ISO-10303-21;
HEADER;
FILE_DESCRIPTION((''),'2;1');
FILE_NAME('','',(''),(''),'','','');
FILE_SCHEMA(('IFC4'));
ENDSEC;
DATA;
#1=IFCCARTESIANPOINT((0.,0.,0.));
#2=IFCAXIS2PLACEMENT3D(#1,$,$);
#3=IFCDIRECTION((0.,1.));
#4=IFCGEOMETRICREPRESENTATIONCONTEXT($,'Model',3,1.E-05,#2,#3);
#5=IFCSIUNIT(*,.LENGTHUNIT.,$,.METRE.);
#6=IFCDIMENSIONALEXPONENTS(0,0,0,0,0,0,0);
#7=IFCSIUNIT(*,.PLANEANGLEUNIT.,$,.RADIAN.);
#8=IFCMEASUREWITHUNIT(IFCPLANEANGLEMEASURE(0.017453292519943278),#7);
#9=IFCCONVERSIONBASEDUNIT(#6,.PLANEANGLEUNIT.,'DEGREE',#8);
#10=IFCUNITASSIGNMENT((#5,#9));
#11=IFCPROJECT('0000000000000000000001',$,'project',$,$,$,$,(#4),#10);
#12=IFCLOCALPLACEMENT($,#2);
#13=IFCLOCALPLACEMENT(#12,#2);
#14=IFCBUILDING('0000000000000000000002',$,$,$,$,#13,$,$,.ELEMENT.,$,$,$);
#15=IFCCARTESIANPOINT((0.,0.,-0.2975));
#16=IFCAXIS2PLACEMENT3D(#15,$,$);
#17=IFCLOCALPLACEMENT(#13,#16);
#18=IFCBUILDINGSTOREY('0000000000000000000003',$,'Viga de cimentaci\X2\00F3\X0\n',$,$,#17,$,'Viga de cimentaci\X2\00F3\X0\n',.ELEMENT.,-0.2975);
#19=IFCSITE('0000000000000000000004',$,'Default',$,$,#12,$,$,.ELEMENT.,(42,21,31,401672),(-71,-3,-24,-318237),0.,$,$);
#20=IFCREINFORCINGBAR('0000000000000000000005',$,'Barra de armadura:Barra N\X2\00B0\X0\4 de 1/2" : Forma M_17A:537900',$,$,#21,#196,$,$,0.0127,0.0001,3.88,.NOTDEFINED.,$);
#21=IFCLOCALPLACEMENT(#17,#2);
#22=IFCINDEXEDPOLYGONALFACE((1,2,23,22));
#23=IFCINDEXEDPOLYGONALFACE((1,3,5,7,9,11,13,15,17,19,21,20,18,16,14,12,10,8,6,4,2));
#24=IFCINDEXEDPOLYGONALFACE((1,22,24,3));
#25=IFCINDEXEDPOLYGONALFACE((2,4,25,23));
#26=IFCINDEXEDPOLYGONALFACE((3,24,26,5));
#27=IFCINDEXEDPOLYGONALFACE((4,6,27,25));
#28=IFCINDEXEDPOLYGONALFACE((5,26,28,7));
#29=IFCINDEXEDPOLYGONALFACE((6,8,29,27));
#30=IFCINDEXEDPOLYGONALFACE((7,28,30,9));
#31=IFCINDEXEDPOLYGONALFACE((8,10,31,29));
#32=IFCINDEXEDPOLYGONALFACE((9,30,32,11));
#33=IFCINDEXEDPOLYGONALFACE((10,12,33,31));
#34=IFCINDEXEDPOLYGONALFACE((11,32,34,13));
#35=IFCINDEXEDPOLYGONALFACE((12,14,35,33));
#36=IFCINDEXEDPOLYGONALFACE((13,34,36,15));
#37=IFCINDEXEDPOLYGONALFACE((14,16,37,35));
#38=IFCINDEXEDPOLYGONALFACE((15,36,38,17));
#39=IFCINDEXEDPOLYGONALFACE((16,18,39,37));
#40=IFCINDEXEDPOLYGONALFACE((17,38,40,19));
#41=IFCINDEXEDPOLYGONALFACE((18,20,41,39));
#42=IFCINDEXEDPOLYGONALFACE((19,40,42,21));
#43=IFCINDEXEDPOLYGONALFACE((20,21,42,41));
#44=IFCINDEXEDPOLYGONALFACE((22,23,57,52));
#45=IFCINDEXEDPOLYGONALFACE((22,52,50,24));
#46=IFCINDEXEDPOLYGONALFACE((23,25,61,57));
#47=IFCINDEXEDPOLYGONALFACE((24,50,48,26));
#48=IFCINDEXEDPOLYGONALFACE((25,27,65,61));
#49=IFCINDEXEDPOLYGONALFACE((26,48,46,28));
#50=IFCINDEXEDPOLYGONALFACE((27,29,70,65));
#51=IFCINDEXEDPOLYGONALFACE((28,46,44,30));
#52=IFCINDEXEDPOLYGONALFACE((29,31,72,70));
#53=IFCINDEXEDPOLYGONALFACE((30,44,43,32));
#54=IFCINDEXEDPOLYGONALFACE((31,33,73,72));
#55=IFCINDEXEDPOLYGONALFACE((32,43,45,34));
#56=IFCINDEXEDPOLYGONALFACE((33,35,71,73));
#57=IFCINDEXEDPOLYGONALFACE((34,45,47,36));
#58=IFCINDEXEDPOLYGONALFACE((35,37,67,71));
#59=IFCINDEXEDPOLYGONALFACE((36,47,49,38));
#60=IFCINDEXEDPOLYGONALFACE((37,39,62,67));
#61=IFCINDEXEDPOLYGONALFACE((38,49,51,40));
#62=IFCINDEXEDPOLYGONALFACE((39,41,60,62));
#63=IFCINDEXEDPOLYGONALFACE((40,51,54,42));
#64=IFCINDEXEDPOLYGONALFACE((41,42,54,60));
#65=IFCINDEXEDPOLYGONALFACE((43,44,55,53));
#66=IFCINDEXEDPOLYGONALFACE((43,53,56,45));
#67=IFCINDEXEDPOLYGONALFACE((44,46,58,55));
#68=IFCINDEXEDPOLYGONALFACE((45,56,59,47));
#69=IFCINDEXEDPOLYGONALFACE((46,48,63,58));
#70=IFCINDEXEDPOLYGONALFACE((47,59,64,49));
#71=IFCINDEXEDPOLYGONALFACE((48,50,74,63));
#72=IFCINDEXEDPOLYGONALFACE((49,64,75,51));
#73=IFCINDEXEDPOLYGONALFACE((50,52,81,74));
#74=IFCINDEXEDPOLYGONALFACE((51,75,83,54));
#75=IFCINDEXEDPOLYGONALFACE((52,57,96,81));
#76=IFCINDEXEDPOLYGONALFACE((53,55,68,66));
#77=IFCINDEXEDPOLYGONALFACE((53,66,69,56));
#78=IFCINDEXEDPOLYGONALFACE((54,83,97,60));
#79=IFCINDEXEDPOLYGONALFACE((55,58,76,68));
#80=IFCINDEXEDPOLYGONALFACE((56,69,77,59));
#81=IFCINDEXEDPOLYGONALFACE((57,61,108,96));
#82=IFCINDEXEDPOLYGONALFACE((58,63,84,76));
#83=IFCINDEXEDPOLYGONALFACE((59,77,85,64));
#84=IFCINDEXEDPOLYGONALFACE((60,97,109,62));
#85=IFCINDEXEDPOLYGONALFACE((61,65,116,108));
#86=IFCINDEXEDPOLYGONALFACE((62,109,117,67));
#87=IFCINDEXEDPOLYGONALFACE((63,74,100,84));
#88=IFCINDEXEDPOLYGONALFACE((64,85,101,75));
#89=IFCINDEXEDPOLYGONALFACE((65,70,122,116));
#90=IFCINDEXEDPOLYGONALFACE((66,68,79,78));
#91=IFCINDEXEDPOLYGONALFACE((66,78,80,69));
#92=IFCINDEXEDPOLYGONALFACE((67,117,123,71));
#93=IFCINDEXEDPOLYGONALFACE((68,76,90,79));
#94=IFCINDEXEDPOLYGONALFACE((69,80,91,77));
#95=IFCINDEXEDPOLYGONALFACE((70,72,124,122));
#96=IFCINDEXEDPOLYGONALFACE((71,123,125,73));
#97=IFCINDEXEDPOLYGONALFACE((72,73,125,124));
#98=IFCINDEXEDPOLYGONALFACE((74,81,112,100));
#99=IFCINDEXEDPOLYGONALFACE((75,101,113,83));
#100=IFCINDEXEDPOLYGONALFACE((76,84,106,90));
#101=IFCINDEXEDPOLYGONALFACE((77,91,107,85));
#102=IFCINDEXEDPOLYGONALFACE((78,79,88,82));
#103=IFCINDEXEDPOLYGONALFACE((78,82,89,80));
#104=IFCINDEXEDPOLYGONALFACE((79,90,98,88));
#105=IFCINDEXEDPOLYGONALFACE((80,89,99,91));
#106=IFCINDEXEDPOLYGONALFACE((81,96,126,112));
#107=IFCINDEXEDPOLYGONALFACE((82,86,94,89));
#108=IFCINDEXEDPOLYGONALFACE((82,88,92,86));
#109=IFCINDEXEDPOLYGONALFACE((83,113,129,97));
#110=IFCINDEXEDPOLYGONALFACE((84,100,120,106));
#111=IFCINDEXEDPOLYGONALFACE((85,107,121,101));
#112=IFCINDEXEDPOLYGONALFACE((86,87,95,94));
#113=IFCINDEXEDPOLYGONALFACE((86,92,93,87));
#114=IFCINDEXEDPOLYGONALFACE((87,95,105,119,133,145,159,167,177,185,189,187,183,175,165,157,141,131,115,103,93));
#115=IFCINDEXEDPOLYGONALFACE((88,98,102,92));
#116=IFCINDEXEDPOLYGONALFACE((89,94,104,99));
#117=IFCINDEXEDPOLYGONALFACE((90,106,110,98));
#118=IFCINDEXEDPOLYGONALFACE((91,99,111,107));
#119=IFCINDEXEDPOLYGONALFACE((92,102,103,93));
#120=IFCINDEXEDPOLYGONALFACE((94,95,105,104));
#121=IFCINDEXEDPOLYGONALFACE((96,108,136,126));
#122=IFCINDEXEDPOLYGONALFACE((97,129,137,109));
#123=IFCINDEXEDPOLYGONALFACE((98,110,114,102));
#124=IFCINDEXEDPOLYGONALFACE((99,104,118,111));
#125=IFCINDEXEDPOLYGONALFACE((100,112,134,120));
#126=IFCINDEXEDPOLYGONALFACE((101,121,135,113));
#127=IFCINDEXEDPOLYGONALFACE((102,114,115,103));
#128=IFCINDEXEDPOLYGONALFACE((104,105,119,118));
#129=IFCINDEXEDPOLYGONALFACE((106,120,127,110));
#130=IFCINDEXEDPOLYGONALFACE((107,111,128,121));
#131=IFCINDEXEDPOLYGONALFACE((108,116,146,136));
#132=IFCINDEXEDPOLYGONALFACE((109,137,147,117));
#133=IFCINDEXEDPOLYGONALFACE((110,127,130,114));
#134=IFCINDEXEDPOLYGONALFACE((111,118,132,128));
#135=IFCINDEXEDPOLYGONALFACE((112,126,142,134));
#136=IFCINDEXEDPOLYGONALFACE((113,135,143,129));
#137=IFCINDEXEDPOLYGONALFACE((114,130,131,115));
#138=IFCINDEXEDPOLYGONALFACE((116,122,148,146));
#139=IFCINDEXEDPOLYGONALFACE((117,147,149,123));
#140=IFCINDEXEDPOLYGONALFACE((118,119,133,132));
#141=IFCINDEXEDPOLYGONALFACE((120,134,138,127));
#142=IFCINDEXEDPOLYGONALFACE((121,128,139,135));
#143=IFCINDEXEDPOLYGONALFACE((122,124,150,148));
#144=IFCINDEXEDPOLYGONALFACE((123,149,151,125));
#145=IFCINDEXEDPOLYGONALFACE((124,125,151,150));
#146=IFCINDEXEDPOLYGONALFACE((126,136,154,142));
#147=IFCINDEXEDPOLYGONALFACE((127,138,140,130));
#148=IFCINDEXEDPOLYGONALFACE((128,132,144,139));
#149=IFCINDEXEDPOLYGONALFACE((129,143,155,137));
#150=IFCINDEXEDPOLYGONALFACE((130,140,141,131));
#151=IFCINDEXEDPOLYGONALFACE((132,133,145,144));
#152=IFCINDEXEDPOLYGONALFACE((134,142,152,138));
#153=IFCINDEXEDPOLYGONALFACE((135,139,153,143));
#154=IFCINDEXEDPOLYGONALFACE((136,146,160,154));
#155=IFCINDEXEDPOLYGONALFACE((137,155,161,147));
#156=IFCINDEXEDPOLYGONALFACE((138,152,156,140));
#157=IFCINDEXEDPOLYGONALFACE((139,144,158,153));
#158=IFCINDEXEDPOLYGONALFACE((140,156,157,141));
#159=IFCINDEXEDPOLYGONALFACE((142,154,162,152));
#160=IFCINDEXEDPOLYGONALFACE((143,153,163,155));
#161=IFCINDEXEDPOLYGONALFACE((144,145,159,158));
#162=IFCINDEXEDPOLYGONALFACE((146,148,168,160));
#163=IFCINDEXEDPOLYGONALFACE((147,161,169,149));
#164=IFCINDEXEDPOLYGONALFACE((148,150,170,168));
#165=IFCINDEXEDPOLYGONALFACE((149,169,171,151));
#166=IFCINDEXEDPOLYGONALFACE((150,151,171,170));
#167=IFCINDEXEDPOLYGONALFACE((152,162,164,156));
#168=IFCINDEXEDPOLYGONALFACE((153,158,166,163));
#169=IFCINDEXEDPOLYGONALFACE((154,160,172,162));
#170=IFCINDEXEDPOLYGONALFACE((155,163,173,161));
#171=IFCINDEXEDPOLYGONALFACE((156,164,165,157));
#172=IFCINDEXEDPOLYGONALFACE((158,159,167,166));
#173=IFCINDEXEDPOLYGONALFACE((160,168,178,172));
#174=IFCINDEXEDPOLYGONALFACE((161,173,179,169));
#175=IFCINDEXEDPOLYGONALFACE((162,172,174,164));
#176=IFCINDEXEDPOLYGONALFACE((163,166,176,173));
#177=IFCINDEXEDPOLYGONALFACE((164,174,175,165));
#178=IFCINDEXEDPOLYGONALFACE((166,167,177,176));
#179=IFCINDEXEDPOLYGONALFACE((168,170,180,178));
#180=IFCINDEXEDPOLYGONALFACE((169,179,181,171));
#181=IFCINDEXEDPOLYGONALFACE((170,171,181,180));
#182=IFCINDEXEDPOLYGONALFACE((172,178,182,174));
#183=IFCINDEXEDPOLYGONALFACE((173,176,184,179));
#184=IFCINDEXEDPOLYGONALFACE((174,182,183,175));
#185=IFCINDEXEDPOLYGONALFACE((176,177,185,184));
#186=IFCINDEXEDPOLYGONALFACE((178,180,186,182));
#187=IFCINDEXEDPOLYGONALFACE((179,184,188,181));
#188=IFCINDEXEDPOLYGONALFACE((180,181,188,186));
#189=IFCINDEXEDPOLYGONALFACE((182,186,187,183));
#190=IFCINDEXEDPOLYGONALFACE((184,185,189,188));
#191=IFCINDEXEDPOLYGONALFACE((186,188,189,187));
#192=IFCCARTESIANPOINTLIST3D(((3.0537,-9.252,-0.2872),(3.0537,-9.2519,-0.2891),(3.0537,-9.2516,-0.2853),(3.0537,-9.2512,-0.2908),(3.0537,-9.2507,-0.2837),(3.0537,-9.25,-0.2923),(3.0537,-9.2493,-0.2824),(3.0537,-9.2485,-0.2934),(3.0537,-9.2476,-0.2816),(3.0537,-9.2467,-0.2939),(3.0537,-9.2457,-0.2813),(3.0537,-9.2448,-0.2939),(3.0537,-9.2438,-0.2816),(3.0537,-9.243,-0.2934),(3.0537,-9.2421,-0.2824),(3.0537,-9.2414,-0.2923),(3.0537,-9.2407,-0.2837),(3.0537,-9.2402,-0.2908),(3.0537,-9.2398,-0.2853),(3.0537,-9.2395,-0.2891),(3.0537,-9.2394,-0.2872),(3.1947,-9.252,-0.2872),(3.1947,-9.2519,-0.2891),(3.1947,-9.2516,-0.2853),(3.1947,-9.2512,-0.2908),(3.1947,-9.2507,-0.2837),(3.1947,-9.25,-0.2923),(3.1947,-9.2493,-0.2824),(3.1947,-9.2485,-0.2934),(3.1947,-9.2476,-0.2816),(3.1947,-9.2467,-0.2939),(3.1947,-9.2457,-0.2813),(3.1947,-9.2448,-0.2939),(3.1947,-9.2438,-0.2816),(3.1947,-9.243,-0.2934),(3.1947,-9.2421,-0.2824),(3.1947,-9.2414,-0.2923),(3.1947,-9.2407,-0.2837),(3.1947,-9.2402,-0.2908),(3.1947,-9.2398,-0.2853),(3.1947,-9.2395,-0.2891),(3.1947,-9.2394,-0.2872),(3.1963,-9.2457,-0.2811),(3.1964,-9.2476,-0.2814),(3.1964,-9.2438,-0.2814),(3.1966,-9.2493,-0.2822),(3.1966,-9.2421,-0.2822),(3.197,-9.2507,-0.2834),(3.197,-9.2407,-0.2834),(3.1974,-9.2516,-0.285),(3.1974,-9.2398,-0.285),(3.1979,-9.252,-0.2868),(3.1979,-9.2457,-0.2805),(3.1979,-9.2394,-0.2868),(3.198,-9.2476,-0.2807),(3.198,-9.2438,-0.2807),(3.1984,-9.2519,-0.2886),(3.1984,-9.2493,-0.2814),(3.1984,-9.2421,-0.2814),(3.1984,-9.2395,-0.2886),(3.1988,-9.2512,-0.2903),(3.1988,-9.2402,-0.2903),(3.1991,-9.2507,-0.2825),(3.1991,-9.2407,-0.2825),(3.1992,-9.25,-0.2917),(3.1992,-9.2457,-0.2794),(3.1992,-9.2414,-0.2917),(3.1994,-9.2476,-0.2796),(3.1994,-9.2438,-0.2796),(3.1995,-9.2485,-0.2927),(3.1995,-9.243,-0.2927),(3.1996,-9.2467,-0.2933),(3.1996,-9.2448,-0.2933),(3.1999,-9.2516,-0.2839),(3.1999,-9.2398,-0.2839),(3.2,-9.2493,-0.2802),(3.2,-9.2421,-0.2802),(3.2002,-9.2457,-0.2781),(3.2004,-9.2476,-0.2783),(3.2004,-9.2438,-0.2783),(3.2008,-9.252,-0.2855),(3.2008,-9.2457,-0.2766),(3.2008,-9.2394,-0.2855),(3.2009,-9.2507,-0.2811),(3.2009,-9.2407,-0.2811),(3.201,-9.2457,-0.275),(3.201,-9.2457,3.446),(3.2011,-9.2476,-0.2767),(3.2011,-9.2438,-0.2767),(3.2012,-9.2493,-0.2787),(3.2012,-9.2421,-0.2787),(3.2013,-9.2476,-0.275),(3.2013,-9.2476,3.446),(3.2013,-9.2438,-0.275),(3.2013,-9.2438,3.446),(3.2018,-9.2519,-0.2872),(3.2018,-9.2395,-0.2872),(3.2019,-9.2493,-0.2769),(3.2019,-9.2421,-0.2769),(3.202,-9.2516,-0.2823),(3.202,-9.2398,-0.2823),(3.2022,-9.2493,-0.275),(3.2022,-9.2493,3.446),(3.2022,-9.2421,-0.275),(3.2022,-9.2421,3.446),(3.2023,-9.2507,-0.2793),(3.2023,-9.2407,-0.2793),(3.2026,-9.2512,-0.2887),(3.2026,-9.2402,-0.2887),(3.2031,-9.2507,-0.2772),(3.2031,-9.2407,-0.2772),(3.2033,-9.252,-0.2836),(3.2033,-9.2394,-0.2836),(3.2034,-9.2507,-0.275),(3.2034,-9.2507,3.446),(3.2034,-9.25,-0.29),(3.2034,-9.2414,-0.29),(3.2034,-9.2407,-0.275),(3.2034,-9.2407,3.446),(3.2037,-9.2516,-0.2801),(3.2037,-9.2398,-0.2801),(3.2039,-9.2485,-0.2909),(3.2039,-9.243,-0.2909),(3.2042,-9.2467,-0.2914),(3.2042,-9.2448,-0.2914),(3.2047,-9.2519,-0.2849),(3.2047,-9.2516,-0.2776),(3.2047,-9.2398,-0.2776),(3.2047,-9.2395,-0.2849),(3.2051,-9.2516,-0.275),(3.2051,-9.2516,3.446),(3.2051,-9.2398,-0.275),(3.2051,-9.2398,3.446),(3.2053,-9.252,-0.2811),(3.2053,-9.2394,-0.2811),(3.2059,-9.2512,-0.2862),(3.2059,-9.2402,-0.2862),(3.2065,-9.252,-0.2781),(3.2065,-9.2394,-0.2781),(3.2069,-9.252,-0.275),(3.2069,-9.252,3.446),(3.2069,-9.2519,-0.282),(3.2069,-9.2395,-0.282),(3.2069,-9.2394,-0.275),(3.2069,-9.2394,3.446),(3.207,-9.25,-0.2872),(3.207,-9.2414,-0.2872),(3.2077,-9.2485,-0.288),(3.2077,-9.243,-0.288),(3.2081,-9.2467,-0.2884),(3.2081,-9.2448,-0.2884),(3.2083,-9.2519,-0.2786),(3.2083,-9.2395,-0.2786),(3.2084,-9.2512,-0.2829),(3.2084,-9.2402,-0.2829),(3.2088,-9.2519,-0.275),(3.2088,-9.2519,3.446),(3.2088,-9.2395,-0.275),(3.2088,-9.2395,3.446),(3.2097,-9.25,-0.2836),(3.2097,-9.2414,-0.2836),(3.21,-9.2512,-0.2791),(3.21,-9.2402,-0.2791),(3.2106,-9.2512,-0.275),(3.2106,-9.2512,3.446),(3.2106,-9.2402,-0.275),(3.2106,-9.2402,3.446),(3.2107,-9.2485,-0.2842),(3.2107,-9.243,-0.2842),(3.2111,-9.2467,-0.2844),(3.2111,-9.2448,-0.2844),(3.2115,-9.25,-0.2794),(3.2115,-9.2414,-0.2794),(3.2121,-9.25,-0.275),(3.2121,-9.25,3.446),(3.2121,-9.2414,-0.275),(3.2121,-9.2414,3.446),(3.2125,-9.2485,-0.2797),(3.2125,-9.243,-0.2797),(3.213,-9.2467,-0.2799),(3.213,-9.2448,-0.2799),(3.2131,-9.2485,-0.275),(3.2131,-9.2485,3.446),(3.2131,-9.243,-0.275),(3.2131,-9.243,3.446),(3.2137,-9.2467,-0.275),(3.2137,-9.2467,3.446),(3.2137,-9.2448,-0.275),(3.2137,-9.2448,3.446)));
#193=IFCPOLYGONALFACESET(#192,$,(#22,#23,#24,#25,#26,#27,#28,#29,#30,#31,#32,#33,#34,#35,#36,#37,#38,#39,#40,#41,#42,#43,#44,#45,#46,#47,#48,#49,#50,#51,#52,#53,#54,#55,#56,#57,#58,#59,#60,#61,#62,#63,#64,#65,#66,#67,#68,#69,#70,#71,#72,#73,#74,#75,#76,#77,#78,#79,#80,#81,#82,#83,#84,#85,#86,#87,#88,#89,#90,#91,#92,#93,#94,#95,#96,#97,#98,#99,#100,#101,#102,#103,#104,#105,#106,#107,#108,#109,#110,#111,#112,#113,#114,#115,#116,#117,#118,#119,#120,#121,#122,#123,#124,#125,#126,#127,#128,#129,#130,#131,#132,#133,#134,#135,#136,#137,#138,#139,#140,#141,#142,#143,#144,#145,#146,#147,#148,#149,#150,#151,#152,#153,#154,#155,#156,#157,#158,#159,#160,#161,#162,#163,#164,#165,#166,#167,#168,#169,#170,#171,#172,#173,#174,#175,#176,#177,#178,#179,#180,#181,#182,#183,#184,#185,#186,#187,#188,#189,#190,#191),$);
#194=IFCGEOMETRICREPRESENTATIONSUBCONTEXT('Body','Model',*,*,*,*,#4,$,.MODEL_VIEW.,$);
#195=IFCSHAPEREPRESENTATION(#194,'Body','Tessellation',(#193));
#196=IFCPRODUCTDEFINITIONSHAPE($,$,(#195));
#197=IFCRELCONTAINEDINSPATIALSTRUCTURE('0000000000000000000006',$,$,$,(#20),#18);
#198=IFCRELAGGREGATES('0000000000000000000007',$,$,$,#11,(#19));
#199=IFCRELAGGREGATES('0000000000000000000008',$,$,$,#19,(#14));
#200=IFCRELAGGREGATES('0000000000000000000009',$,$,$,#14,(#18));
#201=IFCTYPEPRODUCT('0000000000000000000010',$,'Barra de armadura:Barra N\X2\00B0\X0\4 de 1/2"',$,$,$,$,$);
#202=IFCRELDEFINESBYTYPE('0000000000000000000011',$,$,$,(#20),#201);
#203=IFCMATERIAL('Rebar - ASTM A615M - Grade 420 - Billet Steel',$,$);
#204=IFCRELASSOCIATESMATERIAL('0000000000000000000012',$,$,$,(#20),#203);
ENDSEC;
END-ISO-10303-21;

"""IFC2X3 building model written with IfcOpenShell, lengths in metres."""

from ifc_helpers import new_model, entity, si_unit, converted_unit, direction, frame, origin, place, context, subcontext, project, spatial, material, type_object, element, save


model = new_model("IFC2X3")

# Units and contexts
model_context = context("Model", 3, precision=1e-05, world=origin(), true_north=direction((0.0, 1.0)))
body_context = subcontext(model_context, "Body", "Model", "MODEL_VIEW")
ifc_project = project(units=[si_unit("LENGTHUNIT", "METRE"), converted_unit("PLANEANGLEUNIT", "DEGREE", entity("IfcPlaneAngleMeasure", 0.017453292519943278), si_unit("PLANEANGLEUNIT", "RADIAN"), dimensions=[0, 0, 0, 0, 0, 0, 0])], contexts=[model_context])

# Site, building, storey
site_placement = place(None, origin())
site = spatial("IfcSite", under=ifc_project, at=site_placement, Name="Default", CompositionType="ELEMENT", RefLatitude=(42, 21, 31, 401672), RefLongitude=(-71, -3, -24, -318237), RefElevation=0.0)
building_placement = place(site_placement, origin())
building = spatial("IfcBuilding", under=site, at=building_placement, CompositionType="ELEMENT")
storey_placement = place(building_placement, frame((0.0, 0.0, -0.2975)))
storey = spatial("IfcBuildingStorey", under=building, at=storey_placement, Name="Viga de cimentación", LongName="Viga de cimentación", CompositionType="ELEMENT", Elevation=-0.2975)

# Reinforcing bar
ifc_material = material(Name="Rebar - ASTM A615M - Grade 420 - Billet Steel")
type_product_1 = type_object("IfcTypeProduct", Name="Barra de armadura:Barra N°4 de 1/2\"")
reinforcing_bar_1_placement = place(storey_placement, origin())
element("IfcReinforcingBar", 1, at=reinforcing_bar_1_placement, inside=storey, type_object=type_product_1, material=ifc_material, Name="Barra de armadura:Barra N°4 de 1/2\" : Forma M_17A:537900", BarLength=3.88, BarRole="NOTDEFINED", CrossSectionArea=0.0001, NominalDiameter=0.0127, context=body_context, shape_type="AdvancedSweptSolid", body=[
    entity("IfcSweptDiskSolid", entity("IfcCompositeCurve", [entity("IfcCompositeCurveSegment", "CONTINUOUS", True, entity("IfcPolyline", [entity("IfcCartesianPoint", [3.2074, -9.2457, 3.446]), entity("IfcCartesianPoint", [3.2074, -9.2457, -0.275])])), entity("IfcCompositeCurveSegment", "CONTINUOUS", True, entity("IfcTrimmedCurve", entity("IfcCircle", entity("IfcAxis2Placement3D", entity("IfcCartesianPoint", [3.1947, -9.2457, -0.275]), entity("IfcDirection", [0.0, 1.0, 0.0]), entity("IfcDirection", [0.0, 0.0, -1.0])), 0.0127), [entity("IfcParameterValue", 270.0)], [entity("IfcParameterValue", 360.0)], True, "PARAMETER")), entity("IfcCompositeCurveSegment", "CONTINUOUS", True, entity("IfcPolyline", [entity("IfcCartesianPoint", [3.1947, -9.2457, -0.2877]), entity("IfcCartesianPoint", [3.0537, -9.2457, -0.2877])]))], False), 0.0063, None, 0.0, 92.0),
])

save(model, "model.ifc")
